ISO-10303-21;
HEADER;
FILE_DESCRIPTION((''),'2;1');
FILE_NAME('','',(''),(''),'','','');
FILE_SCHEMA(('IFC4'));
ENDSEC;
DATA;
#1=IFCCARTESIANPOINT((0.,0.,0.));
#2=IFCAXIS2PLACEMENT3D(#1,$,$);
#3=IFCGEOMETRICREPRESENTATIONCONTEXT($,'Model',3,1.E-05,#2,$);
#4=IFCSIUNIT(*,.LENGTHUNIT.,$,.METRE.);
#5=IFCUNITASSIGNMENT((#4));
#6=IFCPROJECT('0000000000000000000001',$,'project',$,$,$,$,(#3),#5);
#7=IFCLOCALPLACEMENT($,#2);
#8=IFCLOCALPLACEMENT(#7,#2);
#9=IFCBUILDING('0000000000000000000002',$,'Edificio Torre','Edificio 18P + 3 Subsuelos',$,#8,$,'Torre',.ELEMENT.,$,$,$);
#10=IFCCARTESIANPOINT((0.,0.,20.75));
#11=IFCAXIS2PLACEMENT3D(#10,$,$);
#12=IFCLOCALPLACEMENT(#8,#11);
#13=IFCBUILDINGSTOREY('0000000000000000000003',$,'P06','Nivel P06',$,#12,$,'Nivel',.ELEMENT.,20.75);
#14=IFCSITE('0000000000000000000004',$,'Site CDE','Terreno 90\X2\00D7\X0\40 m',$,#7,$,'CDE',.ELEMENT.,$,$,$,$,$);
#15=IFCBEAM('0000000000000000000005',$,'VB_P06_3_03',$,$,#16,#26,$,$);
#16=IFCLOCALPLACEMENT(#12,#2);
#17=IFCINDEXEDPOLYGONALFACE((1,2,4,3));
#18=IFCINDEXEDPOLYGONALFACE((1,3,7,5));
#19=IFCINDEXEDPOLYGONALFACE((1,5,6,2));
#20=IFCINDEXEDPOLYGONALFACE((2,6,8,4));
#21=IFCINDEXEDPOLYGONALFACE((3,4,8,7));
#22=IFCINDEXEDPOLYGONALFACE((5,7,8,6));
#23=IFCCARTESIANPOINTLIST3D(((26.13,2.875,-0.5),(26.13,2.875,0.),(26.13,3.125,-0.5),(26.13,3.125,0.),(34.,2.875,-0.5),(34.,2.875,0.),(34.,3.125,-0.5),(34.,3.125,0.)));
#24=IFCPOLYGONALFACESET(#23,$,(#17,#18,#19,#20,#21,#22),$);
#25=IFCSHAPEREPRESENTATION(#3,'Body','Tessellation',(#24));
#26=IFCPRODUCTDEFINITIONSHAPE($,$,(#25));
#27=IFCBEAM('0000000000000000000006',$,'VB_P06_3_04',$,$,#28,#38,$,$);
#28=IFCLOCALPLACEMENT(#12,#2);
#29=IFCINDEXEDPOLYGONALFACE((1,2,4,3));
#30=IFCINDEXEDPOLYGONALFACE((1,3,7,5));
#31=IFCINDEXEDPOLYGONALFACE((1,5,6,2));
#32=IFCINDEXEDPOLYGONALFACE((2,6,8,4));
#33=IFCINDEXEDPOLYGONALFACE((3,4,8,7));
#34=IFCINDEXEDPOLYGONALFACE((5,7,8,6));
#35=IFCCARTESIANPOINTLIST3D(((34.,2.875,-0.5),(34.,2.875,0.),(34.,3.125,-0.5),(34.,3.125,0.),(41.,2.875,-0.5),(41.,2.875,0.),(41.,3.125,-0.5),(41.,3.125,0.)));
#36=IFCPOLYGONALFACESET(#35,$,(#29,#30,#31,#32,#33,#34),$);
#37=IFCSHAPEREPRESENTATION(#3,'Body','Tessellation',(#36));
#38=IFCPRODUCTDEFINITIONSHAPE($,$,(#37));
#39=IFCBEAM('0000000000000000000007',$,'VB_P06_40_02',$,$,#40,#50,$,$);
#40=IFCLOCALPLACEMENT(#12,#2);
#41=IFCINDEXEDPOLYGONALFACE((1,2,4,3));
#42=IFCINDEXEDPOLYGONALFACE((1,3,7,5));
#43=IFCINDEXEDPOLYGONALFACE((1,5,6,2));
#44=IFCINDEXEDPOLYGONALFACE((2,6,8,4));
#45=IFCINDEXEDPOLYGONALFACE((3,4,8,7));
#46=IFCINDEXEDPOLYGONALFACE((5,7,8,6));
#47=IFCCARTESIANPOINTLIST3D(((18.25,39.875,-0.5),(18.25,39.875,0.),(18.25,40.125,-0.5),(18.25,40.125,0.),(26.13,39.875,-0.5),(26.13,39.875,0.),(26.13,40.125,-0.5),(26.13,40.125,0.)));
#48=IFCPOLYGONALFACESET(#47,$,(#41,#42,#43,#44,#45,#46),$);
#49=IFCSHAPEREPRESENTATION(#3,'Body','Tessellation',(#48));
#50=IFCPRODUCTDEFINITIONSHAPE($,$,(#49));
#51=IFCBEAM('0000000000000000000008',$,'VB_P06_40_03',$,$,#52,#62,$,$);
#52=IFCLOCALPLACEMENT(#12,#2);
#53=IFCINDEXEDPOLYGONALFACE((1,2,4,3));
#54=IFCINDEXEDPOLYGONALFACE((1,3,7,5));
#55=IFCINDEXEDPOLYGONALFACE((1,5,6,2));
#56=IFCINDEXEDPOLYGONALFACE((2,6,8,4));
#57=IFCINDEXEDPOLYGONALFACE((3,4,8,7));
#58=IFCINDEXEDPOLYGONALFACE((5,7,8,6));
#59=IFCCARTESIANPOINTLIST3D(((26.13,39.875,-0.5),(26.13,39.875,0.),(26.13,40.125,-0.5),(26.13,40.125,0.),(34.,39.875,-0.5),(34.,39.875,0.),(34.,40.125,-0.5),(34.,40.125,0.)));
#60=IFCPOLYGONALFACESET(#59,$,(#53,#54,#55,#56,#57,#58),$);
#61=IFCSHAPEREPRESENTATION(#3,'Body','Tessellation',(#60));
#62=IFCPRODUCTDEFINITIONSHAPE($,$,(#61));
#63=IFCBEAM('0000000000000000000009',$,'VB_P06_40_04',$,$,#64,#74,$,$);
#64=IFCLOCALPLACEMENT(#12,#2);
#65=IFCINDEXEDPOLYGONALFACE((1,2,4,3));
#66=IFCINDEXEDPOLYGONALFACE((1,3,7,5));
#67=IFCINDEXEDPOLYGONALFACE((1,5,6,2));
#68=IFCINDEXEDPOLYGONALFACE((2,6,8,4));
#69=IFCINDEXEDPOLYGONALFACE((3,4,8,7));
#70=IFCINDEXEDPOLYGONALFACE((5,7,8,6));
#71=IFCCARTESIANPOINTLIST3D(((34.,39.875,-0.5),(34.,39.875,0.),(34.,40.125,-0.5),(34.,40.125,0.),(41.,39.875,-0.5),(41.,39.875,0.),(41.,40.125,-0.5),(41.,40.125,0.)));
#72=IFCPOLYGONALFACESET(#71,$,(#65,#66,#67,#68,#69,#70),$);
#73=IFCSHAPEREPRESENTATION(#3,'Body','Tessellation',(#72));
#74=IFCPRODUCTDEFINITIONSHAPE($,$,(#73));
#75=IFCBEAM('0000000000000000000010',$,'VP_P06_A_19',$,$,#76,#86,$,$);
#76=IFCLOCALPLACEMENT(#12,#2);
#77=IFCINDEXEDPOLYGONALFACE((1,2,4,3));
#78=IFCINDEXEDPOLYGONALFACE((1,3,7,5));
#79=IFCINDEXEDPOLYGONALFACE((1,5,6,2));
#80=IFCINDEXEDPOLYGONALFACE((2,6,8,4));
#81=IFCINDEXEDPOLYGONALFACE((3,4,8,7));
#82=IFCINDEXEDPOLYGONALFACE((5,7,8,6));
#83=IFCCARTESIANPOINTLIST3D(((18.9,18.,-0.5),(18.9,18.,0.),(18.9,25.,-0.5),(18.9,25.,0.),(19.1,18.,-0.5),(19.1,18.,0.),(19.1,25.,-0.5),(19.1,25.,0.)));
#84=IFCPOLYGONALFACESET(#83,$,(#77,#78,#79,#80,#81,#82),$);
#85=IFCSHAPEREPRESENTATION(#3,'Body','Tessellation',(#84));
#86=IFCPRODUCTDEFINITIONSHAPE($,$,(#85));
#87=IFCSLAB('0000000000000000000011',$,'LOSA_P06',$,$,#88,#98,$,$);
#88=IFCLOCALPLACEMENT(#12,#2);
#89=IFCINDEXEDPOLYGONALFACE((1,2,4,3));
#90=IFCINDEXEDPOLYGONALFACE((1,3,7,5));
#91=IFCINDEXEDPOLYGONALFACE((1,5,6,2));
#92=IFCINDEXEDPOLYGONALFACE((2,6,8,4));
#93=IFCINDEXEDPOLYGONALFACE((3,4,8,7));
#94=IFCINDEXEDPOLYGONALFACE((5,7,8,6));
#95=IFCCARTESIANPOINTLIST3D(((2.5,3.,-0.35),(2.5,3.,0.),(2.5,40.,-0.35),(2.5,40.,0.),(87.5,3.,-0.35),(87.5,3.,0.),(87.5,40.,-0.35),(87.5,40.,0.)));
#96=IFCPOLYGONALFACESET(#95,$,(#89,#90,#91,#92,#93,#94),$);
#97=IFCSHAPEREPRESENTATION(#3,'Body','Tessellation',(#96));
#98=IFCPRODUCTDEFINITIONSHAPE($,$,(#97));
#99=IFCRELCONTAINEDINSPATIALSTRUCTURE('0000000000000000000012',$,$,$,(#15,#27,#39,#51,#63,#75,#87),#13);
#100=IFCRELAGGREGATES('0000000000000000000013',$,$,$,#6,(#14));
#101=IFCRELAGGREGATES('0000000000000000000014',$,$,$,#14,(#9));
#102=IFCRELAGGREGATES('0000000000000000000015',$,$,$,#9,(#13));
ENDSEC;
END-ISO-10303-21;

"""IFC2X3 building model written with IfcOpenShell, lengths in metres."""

from ifc_helpers import new_model, si_unit, frame, origin, origin_2d, place, context, project, spatial, rectangle, extrude, element, save


model = new_model("IFC2X3")

# Units and contexts
model_context = context("Model", 3, precision=1e-05, world=origin())
ifc_project = project(units=[si_unit("LENGTHUNIT", "METRE")], contexts=[model_context])

# Site, building, storey
site_placement = place(None, origin())
site = spatial("IfcSite", under=ifc_project, at=site_placement, Name="Site CDE", Description="Terreno 90×40 m", LongName="CDE", CompositionType="ELEMENT")
building_placement = place(site_placement, origin())
building = spatial("IfcBuilding", under=site, at=building_placement, Name="Edificio Torre", Description="Edificio 18P + 3 Subsuelos", LongName="Torre", CompositionType="ELEMENT")
storey_placement = place(building_placement, frame((0.0, 0.0, 20.75)))
storey = spatial("IfcBuildingStorey", under=building, at=storey_placement, Name="P06", Description="Nivel P06", LongName="Nivel", CompositionType="ELEMENT", Elevation=20.75)

# Beams
beam_1_placement = place(storey_placement, frame((30.065, 3.0, -0.5)))
element("IfcBeam", 1, at=beam_1_placement, inside=storey, Name="VB_P06_3_03", context=model_context, shape_type="SweptSolid", body=[
    extrude(rectangle(XDim=7.87, YDim=0.25, at=origin_2d()), origin(), (0.0, 0.0, 1.0), 0.5),
])
beam_2_placement = place(storey_placement, frame((37.5, 3.0, -0.5)))
element("IfcBeam", 2, at=beam_2_placement, inside=storey, Name="VB_P06_3_04", context=model_context, shape_type="SweptSolid", body=[
    extrude(rectangle(XDim=7.0, YDim=0.25, at=origin_2d()), origin(), (0.0, 0.0, 1.0), 0.5),
])
beam_3_placement = place(storey_placement, frame((22.19, 40.0, -0.5)))
element("IfcBeam", 3, at=beam_3_placement, inside=storey, Name="VB_P06_40_02", context=model_context, shape_type="SweptSolid", body=[
    extrude(rectangle(XDim=7.88, YDim=0.25, at=origin_2d()), origin(), (0.0, 0.0, 1.0), 0.5),
])
beam_4_placement = place(storey_placement, frame((30.065, 40.0, -0.5)))
element("IfcBeam", 4, at=beam_4_placement, inside=storey, Name="VB_P06_40_03", context=model_context, shape_type="SweptSolid", body=[
    extrude(rectangle(XDim=7.87, YDim=0.25, at=origin_2d()), origin(), (0.0, 0.0, 1.0), 0.5),
])
beam_5_placement = place(storey_placement, frame((37.5, 40.0, -0.5)))
element("IfcBeam", 5, at=beam_5_placement, inside=storey, Name="VB_P06_40_04", context=model_context, shape_type="SweptSolid", body=[
    extrude(rectangle(XDim=7.0, YDim=0.25, at=origin_2d()), origin(), (0.0, 0.0, 1.0), 0.5),
])
beam_6_placement = place(storey_placement, frame((19.0, 21.5, -0.5)))
element("IfcBeam", 6, at=beam_6_placement, inside=storey, Name="VP_P06_A_19", context=model_context, shape_type="SweptSolid", body=[
    extrude(rectangle(XDim=0.2, YDim=7.0, at=origin_2d()), origin(), (0.0, 0.0, 1.0), 0.5),
])

# Slab
slab_placement = place(storey_placement, frame((45.0, 21.5, -0.35)))
element("IfcSlab", 7, at=slab_placement, inside=storey, Name="LOSA_P06", context=model_context, shape_type="SweptSolid", body=[
    extrude(rectangle(XDim=85.0, YDim=37.0, at=origin_2d()), origin(), (0.0, 0.0, 1.0), 0.35),
])

save(model, "model.ifc")
